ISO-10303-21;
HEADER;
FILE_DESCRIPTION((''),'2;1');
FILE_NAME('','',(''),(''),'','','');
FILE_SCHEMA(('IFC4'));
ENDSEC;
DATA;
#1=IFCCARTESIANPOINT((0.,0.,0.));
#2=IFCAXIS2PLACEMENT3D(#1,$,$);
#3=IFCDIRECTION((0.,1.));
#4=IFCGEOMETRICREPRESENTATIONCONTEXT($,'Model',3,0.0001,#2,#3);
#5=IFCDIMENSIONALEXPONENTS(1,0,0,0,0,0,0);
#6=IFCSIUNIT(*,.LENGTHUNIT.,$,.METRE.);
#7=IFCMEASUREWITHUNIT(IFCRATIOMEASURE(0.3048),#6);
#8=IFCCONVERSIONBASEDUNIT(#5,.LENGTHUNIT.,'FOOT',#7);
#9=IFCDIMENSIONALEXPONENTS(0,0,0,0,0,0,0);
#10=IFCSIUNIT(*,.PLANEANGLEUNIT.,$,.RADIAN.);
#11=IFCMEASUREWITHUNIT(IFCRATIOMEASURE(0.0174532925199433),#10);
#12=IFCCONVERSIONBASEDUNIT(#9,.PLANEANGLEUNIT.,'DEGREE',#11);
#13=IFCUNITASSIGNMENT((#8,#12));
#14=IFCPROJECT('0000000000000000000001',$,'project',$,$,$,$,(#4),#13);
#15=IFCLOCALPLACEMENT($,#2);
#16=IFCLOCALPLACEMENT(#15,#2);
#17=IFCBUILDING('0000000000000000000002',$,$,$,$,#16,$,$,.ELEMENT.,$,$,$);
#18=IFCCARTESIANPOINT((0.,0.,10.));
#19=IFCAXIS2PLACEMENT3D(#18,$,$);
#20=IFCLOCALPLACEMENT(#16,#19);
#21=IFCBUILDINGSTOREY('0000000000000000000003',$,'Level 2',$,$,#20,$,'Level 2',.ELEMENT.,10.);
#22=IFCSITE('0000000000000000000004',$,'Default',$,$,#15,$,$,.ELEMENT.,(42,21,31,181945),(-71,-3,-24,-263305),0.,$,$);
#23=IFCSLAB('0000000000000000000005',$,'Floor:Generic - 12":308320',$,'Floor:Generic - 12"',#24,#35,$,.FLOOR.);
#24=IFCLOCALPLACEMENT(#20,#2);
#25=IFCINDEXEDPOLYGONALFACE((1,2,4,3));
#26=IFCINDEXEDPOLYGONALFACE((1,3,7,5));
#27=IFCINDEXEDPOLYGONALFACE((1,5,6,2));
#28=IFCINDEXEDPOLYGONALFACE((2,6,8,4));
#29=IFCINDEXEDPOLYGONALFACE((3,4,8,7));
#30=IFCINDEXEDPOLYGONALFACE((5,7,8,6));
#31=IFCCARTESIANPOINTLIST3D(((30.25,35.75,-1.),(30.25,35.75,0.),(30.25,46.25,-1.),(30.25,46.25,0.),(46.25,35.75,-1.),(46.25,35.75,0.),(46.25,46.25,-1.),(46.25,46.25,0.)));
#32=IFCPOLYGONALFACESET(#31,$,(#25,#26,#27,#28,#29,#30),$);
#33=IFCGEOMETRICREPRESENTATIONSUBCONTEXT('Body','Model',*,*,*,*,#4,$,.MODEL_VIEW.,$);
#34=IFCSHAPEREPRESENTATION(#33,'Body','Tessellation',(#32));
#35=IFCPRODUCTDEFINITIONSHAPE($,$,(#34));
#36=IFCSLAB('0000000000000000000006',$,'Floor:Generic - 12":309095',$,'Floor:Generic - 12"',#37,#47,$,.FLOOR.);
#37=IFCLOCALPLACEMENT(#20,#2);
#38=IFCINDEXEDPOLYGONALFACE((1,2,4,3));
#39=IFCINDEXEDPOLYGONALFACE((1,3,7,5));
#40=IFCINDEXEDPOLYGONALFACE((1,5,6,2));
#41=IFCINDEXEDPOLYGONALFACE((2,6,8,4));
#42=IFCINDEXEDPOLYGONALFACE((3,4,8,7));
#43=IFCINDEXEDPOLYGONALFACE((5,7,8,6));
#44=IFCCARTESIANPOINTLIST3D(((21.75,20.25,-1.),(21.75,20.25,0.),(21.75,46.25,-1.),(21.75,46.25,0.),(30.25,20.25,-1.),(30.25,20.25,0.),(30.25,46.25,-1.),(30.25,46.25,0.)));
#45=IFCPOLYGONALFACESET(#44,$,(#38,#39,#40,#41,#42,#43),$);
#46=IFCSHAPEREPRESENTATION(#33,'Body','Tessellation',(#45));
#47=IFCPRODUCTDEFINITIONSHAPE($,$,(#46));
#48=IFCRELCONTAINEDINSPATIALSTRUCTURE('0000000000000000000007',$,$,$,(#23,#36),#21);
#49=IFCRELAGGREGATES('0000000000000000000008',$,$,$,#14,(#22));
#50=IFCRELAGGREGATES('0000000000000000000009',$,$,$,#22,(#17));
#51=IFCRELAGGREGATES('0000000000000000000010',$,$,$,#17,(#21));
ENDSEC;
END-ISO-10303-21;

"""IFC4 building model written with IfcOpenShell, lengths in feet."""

from ifc_helpers import new_model, entity, si_unit, converted_unit, direction, frame, frame_2d, origin, place, context, subcontext, project, spatial, rectangle, extrude, element, save


model = new_model("IFC4")

# Units and contexts
model_context = context("Model", 3, precision=0.0001, world=origin(), true_north=direction((0.0, 1.0)))
body_context = subcontext(model_context, "Body", "Model", "MODEL_VIEW")
ifc_project = project(units=[converted_unit("LENGTHUNIT", "FOOT", entity("IfcRatioMeasure", 0.3048), si_unit("LENGTHUNIT", "METRE"), dimensions=[1, 0, 0, 0, 0, 0, 0]), converted_unit("PLANEANGLEUNIT", "DEGREE", entity("IfcRatioMeasure", 0.0174532925199433), si_unit("PLANEANGLEUNIT", "RADIAN"), dimensions=[0, 0, 0, 0, 0, 0, 0])], contexts=[model_context])

# Site, building, storey
site_placement = place(None, origin())
site = spatial("IfcSite", under=ifc_project, at=site_placement, Name="Default", CompositionType="ELEMENT", RefLatitude=(42, 21, 31, 181945), RefLongitude=(-71, -3, -24, -263305), RefElevation=0.0)
building_placement = place(site_placement, origin())
building = spatial("IfcBuilding", under=site, at=building_placement, CompositionType="ELEMENT")
storey_placement = place(building_placement, frame((0.0, 0.0, 10.0)))
storey = spatial("IfcBuildingStorey", under=building, at=storey_placement, Name="Level 2", LongName="Level 2", CompositionType="ELEMENT", Elevation=10.0)

# Slabs
slab_1_placement = place(storey_placement, origin())
element("IfcSlab", 1, at=slab_1_placement, inside=storey, Name="Floor:Generic - 12\":308320", ObjectType="Floor:Generic - 12\"", PredefinedType="FLOOR", context=body_context, shape_type="SweptSolid", body=[
    extrude(rectangle(XDim=10.5, YDim=16.0, at=frame_2d((0.0, 0.0), x_axis=(1.0, 0.0))), frame((38.25, 41.0, 0.0), z_axis=(0.0, 0.0, -1.0), x_axis=(0.0, 1.0, 0.0)), (0.0, 0.0, 1.0), 1.0),
])
slab_2_placement = place(storey_placement, origin())
element("IfcSlab", 2, at=slab_2_placement, inside=storey, Name="Floor:Generic - 12\":309095", ObjectType="Floor:Generic - 12\"", PredefinedType="FLOOR", context=body_context, shape_type="SweptSolid", body=[
    extrude(rectangle(XDim=26.0, YDim=8.5, at=frame_2d((0.0, 0.0), x_axis=(1.0, 0.0))), frame((26.0, 33.25, 0.0), z_axis=(0.0, 0.0, -1.0), x_axis=(0.0, 1.0, 0.0)), (0.0, 0.0, 1.0), 1.0),
])

save(model, "model.ifc")
